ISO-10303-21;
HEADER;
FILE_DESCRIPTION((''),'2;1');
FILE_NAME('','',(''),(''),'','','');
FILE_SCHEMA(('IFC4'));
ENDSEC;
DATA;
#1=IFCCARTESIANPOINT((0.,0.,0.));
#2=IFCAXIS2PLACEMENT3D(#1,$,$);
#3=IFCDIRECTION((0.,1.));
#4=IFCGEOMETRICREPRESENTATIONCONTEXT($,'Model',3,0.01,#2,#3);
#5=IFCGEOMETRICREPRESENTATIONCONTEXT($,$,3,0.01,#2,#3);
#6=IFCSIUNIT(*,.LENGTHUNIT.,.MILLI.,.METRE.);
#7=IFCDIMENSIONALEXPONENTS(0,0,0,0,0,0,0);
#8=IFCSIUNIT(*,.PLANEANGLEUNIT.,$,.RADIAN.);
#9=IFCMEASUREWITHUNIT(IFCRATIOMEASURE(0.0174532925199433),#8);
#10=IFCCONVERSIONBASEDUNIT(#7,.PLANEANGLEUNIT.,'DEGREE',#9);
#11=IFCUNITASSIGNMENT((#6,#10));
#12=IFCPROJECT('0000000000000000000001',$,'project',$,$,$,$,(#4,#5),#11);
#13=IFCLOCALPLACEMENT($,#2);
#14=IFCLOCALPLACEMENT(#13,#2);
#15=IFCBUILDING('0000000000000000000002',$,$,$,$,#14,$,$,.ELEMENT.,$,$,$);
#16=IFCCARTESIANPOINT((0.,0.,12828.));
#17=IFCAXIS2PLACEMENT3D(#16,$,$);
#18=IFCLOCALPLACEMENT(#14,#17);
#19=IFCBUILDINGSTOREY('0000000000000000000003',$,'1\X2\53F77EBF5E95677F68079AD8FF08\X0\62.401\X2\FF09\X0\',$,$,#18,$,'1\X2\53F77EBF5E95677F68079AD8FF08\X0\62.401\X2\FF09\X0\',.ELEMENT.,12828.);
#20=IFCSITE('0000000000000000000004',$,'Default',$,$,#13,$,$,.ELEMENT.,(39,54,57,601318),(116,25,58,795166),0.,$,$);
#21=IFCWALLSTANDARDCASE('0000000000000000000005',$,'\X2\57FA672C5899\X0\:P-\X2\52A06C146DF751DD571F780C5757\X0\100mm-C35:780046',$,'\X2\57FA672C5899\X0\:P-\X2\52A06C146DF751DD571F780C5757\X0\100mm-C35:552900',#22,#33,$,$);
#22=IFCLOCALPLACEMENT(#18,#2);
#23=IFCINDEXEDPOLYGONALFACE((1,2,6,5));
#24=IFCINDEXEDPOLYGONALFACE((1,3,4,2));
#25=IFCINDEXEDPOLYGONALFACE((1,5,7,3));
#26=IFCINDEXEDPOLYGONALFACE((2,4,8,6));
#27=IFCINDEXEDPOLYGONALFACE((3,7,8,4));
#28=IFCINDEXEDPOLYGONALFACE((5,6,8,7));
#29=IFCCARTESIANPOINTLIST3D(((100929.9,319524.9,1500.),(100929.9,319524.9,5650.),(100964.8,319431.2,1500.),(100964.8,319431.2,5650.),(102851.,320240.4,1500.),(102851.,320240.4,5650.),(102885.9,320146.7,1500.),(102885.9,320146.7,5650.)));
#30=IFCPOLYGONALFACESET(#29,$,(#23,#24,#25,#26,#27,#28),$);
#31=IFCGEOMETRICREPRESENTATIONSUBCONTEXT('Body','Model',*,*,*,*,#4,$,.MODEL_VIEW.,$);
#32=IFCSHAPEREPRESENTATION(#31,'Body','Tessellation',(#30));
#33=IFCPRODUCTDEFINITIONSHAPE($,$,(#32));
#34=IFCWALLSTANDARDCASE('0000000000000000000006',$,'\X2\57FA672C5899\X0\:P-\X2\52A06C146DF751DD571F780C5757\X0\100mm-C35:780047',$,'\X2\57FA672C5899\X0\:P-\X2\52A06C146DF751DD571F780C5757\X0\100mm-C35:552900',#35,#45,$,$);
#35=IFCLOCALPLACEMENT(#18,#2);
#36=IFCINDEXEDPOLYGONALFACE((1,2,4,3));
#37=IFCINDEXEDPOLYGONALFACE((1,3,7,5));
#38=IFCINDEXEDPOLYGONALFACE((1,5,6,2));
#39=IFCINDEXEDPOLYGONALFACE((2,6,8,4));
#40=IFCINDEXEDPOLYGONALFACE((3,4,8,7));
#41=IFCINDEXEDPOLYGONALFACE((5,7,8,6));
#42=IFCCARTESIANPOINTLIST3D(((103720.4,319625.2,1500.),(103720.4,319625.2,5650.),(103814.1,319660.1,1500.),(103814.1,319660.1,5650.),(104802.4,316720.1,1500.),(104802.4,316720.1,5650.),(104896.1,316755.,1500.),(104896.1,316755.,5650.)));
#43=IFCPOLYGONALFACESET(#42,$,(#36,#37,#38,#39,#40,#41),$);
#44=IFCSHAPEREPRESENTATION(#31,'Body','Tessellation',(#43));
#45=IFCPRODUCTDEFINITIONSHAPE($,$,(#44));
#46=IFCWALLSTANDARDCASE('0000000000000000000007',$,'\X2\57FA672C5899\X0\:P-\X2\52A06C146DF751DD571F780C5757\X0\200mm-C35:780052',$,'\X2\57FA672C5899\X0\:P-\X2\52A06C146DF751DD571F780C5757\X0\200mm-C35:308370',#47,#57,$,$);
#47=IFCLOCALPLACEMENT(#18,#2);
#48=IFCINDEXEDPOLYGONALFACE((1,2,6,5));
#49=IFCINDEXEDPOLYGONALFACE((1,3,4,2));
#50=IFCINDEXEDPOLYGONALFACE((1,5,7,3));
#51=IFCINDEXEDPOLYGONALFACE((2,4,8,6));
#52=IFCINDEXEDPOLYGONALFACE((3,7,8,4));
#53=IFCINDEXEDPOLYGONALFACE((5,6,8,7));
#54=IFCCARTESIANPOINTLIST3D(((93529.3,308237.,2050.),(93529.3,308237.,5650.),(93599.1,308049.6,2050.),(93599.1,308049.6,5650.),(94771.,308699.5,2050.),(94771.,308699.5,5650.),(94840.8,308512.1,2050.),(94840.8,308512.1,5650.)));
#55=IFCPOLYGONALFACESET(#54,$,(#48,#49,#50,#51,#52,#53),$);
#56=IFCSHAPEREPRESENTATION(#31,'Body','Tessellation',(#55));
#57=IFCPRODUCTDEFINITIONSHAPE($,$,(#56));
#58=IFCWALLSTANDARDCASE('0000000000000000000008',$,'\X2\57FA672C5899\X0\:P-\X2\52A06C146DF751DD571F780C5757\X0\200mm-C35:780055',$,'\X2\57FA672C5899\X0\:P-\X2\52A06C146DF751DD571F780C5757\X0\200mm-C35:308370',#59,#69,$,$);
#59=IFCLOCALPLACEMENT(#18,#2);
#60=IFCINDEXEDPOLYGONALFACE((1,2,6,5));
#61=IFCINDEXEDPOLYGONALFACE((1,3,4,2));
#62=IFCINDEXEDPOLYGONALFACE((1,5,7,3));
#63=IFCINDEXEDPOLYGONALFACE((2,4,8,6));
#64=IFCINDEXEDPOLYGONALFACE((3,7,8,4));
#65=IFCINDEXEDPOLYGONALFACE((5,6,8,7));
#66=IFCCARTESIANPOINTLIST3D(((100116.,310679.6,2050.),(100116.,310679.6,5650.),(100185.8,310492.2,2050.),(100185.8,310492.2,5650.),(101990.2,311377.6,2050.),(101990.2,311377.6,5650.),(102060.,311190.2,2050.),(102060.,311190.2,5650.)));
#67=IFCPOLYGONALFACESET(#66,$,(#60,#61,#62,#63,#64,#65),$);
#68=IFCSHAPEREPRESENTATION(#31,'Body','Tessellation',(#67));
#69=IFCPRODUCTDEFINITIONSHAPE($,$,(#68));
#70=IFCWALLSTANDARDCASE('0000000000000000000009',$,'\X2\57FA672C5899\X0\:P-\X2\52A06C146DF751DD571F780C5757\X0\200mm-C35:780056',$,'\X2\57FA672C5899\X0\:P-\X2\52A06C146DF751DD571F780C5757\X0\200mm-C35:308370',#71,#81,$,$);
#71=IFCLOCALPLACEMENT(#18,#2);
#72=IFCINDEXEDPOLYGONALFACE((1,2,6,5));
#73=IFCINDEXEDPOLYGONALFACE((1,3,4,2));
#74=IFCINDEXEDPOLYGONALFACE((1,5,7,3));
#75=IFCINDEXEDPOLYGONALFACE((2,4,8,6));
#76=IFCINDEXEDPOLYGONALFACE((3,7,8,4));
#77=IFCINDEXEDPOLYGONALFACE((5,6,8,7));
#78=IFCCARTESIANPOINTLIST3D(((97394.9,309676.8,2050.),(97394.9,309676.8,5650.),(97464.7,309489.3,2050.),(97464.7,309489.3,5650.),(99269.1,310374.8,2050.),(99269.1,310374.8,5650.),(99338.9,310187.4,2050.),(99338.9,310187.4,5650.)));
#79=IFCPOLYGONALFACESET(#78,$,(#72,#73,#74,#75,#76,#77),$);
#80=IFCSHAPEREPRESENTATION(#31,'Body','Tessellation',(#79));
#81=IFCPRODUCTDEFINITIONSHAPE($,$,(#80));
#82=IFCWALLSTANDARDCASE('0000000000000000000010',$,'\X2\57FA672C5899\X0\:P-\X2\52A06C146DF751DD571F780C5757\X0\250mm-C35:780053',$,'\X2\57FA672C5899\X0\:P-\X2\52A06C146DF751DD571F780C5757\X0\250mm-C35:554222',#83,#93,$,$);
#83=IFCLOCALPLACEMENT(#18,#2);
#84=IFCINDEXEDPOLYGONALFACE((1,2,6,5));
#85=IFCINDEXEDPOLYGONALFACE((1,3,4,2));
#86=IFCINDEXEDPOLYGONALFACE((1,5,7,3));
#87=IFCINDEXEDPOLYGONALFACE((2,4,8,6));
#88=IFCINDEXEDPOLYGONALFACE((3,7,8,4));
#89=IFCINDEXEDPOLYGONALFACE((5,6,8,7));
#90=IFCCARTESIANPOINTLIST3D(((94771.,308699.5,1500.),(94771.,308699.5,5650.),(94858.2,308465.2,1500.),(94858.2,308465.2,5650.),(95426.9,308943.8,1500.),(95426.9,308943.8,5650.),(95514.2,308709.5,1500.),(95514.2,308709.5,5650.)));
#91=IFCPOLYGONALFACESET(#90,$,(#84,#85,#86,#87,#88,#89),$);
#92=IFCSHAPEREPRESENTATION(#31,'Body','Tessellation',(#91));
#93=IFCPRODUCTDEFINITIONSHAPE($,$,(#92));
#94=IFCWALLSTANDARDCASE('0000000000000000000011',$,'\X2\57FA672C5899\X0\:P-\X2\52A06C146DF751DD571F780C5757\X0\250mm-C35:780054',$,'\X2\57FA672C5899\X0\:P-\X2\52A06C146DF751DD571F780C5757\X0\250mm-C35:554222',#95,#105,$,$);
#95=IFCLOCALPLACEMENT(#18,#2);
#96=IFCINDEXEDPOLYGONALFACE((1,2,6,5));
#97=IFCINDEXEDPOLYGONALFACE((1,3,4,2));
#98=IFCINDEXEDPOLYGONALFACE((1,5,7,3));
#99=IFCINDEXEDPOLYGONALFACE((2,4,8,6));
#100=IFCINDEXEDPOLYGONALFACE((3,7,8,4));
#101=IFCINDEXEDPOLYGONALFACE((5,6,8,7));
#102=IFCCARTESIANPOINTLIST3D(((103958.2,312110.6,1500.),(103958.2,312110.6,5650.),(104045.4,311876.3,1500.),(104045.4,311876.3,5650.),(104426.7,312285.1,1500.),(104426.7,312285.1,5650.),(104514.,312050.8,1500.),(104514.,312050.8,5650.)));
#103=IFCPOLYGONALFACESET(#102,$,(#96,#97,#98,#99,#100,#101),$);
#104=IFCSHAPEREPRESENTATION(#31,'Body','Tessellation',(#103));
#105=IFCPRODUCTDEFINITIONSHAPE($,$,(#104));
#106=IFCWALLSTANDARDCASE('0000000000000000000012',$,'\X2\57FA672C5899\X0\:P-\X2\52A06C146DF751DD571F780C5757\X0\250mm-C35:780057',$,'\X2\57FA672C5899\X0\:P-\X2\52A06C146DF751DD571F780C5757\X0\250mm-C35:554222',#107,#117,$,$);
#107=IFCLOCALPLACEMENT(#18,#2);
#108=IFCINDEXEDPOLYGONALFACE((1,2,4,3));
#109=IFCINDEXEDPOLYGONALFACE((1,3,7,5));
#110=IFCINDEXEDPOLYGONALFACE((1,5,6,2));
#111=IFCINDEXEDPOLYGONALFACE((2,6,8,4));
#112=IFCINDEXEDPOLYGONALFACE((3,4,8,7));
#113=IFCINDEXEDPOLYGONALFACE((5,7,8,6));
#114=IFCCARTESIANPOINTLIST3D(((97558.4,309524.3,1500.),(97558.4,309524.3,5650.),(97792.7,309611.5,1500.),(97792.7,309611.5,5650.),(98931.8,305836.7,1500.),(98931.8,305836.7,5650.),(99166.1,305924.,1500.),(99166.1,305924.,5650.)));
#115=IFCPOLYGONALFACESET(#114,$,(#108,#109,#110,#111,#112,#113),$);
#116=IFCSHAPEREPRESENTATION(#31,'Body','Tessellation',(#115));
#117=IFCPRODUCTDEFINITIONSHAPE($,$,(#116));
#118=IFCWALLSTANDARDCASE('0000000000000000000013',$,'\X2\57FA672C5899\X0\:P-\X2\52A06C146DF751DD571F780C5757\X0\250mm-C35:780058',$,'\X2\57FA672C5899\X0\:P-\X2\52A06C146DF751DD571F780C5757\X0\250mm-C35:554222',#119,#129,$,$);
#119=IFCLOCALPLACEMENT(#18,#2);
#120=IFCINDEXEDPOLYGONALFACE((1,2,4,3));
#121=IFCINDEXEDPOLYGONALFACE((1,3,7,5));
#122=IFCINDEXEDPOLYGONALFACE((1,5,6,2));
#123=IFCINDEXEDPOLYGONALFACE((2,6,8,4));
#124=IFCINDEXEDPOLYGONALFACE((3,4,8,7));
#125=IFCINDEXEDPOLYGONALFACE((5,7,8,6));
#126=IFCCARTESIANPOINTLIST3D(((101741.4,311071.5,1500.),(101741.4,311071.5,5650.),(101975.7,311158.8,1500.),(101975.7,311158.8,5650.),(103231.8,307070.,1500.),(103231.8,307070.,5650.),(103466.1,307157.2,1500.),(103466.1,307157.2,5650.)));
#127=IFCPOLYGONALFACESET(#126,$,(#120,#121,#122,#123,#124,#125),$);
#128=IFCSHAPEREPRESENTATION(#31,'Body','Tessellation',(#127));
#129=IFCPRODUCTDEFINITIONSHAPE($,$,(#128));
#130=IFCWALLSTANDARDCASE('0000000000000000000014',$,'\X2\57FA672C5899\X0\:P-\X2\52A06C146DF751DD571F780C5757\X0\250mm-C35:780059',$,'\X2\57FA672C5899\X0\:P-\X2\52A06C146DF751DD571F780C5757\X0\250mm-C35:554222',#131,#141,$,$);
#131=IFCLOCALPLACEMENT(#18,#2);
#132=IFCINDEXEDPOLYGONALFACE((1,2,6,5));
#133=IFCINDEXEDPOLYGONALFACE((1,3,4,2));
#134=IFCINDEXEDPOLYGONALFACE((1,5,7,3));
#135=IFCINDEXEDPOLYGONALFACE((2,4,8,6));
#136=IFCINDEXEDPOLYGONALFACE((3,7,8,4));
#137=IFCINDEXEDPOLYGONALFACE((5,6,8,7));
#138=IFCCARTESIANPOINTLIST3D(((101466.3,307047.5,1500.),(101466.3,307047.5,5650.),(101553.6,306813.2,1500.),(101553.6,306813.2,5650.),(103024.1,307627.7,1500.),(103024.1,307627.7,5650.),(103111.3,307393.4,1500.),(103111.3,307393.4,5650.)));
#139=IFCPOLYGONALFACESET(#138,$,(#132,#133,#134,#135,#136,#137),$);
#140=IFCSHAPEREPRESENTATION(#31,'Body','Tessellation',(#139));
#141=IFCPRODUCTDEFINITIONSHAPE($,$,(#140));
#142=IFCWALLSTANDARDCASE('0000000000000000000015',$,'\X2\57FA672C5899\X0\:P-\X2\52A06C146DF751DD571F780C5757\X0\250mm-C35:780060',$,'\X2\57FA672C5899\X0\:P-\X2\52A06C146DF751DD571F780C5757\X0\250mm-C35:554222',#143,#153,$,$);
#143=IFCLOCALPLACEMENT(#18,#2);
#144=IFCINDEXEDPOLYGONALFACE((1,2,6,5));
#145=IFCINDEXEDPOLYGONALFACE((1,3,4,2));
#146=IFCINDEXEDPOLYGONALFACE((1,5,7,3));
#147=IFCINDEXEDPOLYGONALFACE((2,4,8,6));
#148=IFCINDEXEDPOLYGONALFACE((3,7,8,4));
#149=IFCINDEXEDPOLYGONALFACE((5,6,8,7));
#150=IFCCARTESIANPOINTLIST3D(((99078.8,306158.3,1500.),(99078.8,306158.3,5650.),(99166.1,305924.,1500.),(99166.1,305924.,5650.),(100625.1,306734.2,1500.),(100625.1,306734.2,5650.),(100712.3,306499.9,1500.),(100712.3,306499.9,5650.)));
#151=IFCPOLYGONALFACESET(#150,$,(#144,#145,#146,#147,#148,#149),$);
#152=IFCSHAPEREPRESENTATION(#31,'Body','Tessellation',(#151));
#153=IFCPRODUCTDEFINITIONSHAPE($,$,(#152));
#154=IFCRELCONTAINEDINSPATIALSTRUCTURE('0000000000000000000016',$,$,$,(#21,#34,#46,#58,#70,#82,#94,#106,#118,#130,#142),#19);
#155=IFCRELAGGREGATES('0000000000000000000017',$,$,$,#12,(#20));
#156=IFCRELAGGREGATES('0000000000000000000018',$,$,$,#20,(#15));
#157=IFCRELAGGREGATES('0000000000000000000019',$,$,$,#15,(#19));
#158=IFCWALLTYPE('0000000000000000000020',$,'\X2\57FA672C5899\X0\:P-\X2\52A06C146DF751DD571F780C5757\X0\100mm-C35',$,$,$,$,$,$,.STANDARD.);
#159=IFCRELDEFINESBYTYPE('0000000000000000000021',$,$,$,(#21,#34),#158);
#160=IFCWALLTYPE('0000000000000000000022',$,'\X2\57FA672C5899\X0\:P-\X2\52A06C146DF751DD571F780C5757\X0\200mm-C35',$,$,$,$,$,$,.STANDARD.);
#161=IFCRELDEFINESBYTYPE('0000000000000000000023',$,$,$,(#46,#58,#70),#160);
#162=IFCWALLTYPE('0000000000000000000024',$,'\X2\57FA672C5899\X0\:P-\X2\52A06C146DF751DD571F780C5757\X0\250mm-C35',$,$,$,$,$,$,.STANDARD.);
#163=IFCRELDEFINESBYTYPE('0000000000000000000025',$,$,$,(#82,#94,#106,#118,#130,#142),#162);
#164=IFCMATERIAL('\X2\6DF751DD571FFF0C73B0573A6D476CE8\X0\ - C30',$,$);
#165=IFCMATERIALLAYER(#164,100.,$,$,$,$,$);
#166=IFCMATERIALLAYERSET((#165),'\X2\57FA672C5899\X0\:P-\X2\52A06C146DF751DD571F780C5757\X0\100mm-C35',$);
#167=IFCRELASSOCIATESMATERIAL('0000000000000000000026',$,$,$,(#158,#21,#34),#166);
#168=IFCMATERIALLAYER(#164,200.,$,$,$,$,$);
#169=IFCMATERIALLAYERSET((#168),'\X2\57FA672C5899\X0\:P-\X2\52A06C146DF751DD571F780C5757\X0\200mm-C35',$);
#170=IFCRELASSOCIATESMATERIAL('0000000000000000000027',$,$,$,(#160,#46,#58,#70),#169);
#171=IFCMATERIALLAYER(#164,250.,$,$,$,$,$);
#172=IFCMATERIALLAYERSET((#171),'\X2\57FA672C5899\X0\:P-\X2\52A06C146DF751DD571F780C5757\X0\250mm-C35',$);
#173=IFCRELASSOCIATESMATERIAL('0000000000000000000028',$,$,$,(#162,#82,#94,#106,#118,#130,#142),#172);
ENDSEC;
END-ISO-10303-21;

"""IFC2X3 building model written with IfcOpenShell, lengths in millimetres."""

from ifc_helpers import new_model, entity, si_unit, converted_unit, direction, frame, frame_2d, origin, place, context, subcontext, project, spatial, polyline, rectangle, extrude, clip, bounded_halfspace, material, layer, layer_set, layer_usage, type_object, element, save


model = new_model("IFC2X3")

# Units and contexts
model_context = context("Model", 3, precision=0.01, world=origin(), true_north=direction((0.0, 1.0)))
context_of_model = context(None, 3, precision=0.01, world=origin(), true_north=direction((0.0, 1.0)))
body_context = subcontext(model_context, "Body", "Model", "MODEL_VIEW")
ifc_project = project(units=[si_unit("LENGTHUNIT", "METRE", prefix="MILLI"), converted_unit("PLANEANGLEUNIT", "DEGREE", entity("IfcRatioMeasure", 0.0174532925199433), si_unit("PLANEANGLEUNIT", "RADIAN"), dimensions=[0, 0, 0, 0, 0, 0, 0])], contexts=[model_context, context_of_model])

# Site, building, storey
site_placement = place(None, origin())
site = spatial("IfcSite", under=ifc_project, at=site_placement, Name="Default", CompositionType="ELEMENT", RefLatitude=(39, 54, 57, 601318), RefLongitude=(116, 25, 58, 795166), RefElevation=0.0)
building_placement = place(site_placement, origin())
building = spatial("IfcBuilding", under=site, at=building_placement, CompositionType="ELEMENT")
storey_placement = place(building_placement, frame((0.0, 0.0, 12828.0)))
storey = spatial("IfcBuildingStorey", under=building, at=storey_placement, Name="1号线底板标高（62.401）", LongName="1号线底板标高（62.401）", CompositionType="ELEMENT", Elevation=12828.0)

# Walls
ifc_material_1 = material(Name="混凝土，现场浇注 - C30")
ifc_layer_1 = layer(ifc_material_1, 100.0)
ifc_layer_set_1 = layer_set([ifc_layer_1], Name="基本墙:P-加气混凝土砌块100mm-C35")
ifc_layer_usage_1 = layer_usage(ifc_layer_set_1, "AXIS2", "NEGATIVE", 50.0)
wall_type_1 = type_object("IfcWallType", Name="基本墙:P-加气混凝土砌块100mm-C35", PredefinedType="STANDARD", material=ifc_layer_set_1)
wall_1_placement = place(storey_placement, frame((100947.4, 319478.1, 1500.0), z_axis=(0.0, 0.0, 1.0), x_axis=(0.937112, 0.349028, 0.0)))
element("IfcWallStandardCase", 1, at=wall_1_placement, inside=storey, type_object=wall_type_1, material=ifc_layer_usage_1, Name="基本墙:P-加气混凝土砌块100mm-C35:780046", ObjectType="基本墙:P-加气混凝土砌块100mm-C35:552900", context=body_context, shape_type="Clipping", body=[
    clip(extrude(rectangle(XDim=2050.0, YDim=100.0, at=frame_2d((1025.0, 0.0), x_axis=(-1.0, 0.0))), origin(), (0.0, 0.0, 1.0), 4150.0), bounded_halfspace(frame((0.0, -50.0, 4150.0), z_axis=(0.0, 0.0, -1.0), x_axis=(1.0, 0.0, 0.0)), True, frame((0.0, -50.0, 4150.0)), polyline([(0.0, 0.0), (2050.0, 0.0), (2050.0, 100.0), (0.0, 100.0), (0.0, 0.0)]))),
])
ifc_layer_usage_2 = layer_usage(ifc_layer_set_1, "AXIS2", "NEGATIVE", 50.0)
wall_2_placement = place(storey_placement, frame((103767.3, 319642.6, 1500.0), z_axis=(0.0, 0.0, 1.0), x_axis=(0.349028, -0.937112, 0.0)))
element("IfcWallStandardCase", 2, at=wall_2_placement, inside=storey, type_object=wall_type_1, material=ifc_layer_usage_2, Name="基本墙:P-加气混凝土砌块100mm-C35:780047", ObjectType="基本墙:P-加气混凝土砌块100mm-C35:552900", context=body_context, shape_type="Clipping", body=[
    clip(extrude(rectangle(XDim=3100.0, YDim=100.0, at=frame_2d((1550.0, 0.0), x_axis=(-1.0, 0.0))), origin(), (0.0, 0.0, 1.0), 4150.0), bounded_halfspace(frame((0.0, -50.0, 4150.0), z_axis=(0.0, 0.0, -1.0), x_axis=(0.0, 1.0, 0.0)), True, frame((0.0, -50.0, 4150.0)), polyline([(0.0, 0.0), (3100.0, 0.0), (3100.0, 100.0), (0.0, 100.0), (0.0, 0.0)]))),
])
ifc_layer_2 = layer(ifc_material_1, 200.0)
ifc_layer_set_2 = layer_set([ifc_layer_2], Name="基本墙:P-加气混凝土砌块200mm-C35")
ifc_layer_usage_3 = layer_usage(ifc_layer_set_2, "AXIS2", "NEGATIVE", 100.0)
wall_type_2 = type_object("IfcWallType", Name="基本墙:P-加气混凝土砌块200mm-C35", PredefinedType="STANDARD", material=ifc_layer_set_2)
wall_3_placement = place(storey_placement, frame((94805.9, 308605.8, 2050.0), z_axis=(0.0, 0.0, 1.0), x_axis=(-0.937112, -0.349028, 0.0)))
element("IfcWallStandardCase", 3, at=wall_3_placement, inside=storey, type_object=wall_type_2, material=ifc_layer_usage_3, Name="基本墙:P-加气混凝土砌块200mm-C35:780052", ObjectType="基本墙:P-加气混凝土砌块200mm-C35:308370", context=body_context, shape_type="Clipping", body=[
    clip(extrude(rectangle(XDim=1325.0, YDim=200.0, at=frame_2d((662.5, 0.0), x_axis=(-1.0, 0.0))), origin(), (0.0, 0.0, 1.0), 3600.0), bounded_halfspace(frame((0.0, -100.0, 3600.0), z_axis=(0.0, 0.0, -1.0), x_axis=(-1.0, 0.0, 0.0)), True, frame((0.0, -100.0, 3600.0)), polyline([(0.0, 0.0), (1325.0, 0.0), (1325.0, 200.0), (0.0, 200.0), (0.0, 0.0)]))),
])
ifc_layer_usage_4 = layer_usage(ifc_layer_set_2, "AXIS2", "NEGATIVE", 100.0)
wall_4_placement = place(storey_placement, frame((100150.9, 310585.9, 2050.0), z_axis=(0.0, 0.0, 1.0), x_axis=(0.937112, 0.349028, 0.0)))
element("IfcWallStandardCase", 4, at=wall_4_placement, inside=storey, type_object=wall_type_2, material=ifc_layer_usage_4, Name="基本墙:P-加气混凝土砌块200mm-C35:780055", ObjectType="基本墙:P-加气混凝土砌块200mm-C35:308370", context=body_context, shape_type="Clipping", body=[
    clip(extrude(rectangle(XDim=2000.0, YDim=200.0, at=frame_2d((1000.0, 0.0), x_axis=(-1.0, 0.0))), origin(), (0.0, 0.0, 1.0), 3600.0), bounded_halfspace(frame((0.0, -100.0, 3600.0), z_axis=(0.0, 0.0, -1.0), x_axis=(1.0, 0.0, 0.0)), True, frame((0.0, -100.0, 3600.0)), polyline([(0.0, 0.0), (1660.0, 0.0), (1910.0, 0.0), (2000.0, 0.0), (2000.0, 200.0), (0.0, 200.0), (0.0, 0.0)]))),
])
ifc_layer_usage_5 = layer_usage(ifc_layer_set_2, "AXIS2", "NEGATIVE", 100.0)
wall_5_placement = place(storey_placement, frame((97429.8, 309583.1, 2050.0), z_axis=(0.0, 0.0, 1.0), x_axis=(0.937112, 0.349028, 0.0)))
element("IfcWallStandardCase", 5, at=wall_5_placement, inside=storey, type_object=wall_type_2, material=ifc_layer_usage_5, Name="基本墙:P-加气混凝土砌块200mm-C35:780056", ObjectType="基本墙:P-加气混凝土砌块200mm-C35:308370", context=body_context, shape_type="Clipping", body=[
    clip(extrude(rectangle(XDim=2000.0, YDim=200.0, at=frame_2d((1000.0, 0.0), x_axis=(-1.0, 0.0))), origin(), (0.0, 0.0, 1.0), 3600.0), bounded_halfspace(frame((0.0, -100.0, 3600.0), z_axis=(0.0, 0.0, -1.0), x_axis=(1.0, 0.0, 0.0)), True, frame((0.0, -100.0, 3600.0)), polyline([(0.0, 0.0), (100.0, 0.0), (350.0, 0.0), (2000.0, 0.0), (2000.0, 200.0), (0.0, 200.0), (0.0, 0.0)]))),
])
ifc_layer_3 = layer(ifc_material_1, 250.0)
ifc_layer_set_3 = layer_set([ifc_layer_3], Name="基本墙:P-加气混凝土砌块250mm-C35")
ifc_layer_usage_6 = layer_usage(ifc_layer_set_3, "AXIS2", "NEGATIVE", 125.0)
wall_type_3 = type_object("IfcWallType", Name="基本墙:P-加气混凝土砌块250mm-C35", PredefinedType="STANDARD", material=ifc_layer_set_3)
wall_6_placement = place(storey_placement, frame((94814.6, 308582.4, 1500.0), z_axis=(0.0, 0.0, 1.0), x_axis=(0.937112, 0.349028, 0.0)))
element("IfcWallStandardCase", 6, at=wall_6_placement, inside=storey, type_object=wall_type_3, material=ifc_layer_usage_6, Name="基本墙:P-加气混凝土砌块250mm-C35:780053", ObjectType="基本墙:P-加气混凝土砌块250mm-C35:554222", context=body_context, shape_type="Clipping", body=[
    clip(extrude(rectangle(XDim=700.0, YDim=250.0, at=frame_2d((350.0, 0.0), x_axis=(-1.0, 0.0))), origin(), (0.0, 0.0, 1.0), 4150.0), bounded_halfspace(frame((0.0, -125.0, 4150.0), z_axis=(0.0, 0.0, -1.0), x_axis=(1.0, 0.0, 0.0)), True, frame((0.0, -125.0, 4150.0)), polyline([(0.0, 0.0), (700.0, 0.0), (700.0, 250.0), (0.0, 250.0), (0.0, 50.0), (0.0, 0.0)]))),
])
ifc_layer_usage_7 = layer_usage(ifc_layer_set_3, "AXIS2", "NEGATIVE", 125.0)
wall_7_placement = place(storey_placement, frame((104001.8, 311993.5, 1500.0), z_axis=(0.0, 0.0, 1.0), x_axis=(0.937112, 0.349028, 0.0)))
element("IfcWallStandardCase", 7, at=wall_7_placement, inside=storey, type_object=wall_type_3, material=ifc_layer_usage_7, Name="基本墙:P-加气混凝土砌块250mm-C35:780054", ObjectType="基本墙:P-加气混凝土砌块250mm-C35:554222", context=body_context, shape_type="Clipping", body=[
    clip(extrude(rectangle(XDim=500.0, YDim=250.0, at=frame_2d((250.0, 0.0), x_axis=(-1.0, 0.0))), origin(), (0.0, 0.0, 1.0), 4150.0), bounded_halfspace(frame((0.0, -125.0, 4150.0), z_axis=(0.0, 0.0, -1.0), x_axis=(1.0, 0.0, 0.0)), True, frame((0.0, -125.0, 4150.0)), polyline([(0.0, 0.0), (500.0, 0.0), (500.0, 50.0), (500.0, 250.0), (0.0, 250.0), (0.0, 0.0)]))),
])
ifc_layer_usage_8 = layer_usage(ifc_layer_set_3, "AXIS2", "NEGATIVE", 125.0)
wall_8_placement = place(storey_placement, frame((97675.5, 309567.9, 1500.0), z_axis=(0.0, 0.0, 1.0), x_axis=(0.349028, -0.937112, 0.0)))
element("IfcWallStandardCase", 8, at=wall_8_placement, inside=storey, type_object=wall_type_3, material=ifc_layer_usage_8, Name="基本墙:P-加气混凝土砌块250mm-C35:780057", ObjectType="基本墙:P-加气混凝土砌块250mm-C35:554222", context=body_context, shape_type="Clipping", body=[
    clip(extrude(rectangle(XDim=3935.0, YDim=250.0, at=frame_2d((1967.5, 0.0), x_axis=(-1.0, 0.0))), origin(), (0.0, 0.0, 1.0), 4150.0), bounded_halfspace(frame((0.0, -125.0, 4150.0), z_axis=(0.0, 0.0, -1.0), x_axis=(0.0, 1.0, 0.0)), True, frame((0.0, -125.0, 4150.0)), polyline([(0.0, 0.0), (3935.0, 0.0), (3935.0, 250.0), (3685.0, 250.0), (835.0, 250.0), (585.0, 250.0), (0.0, 250.0), (0.0, 0.0)]))),
])
ifc_layer_usage_9 = layer_usage(ifc_layer_set_3, "AXIS2", "NEGATIVE", 125.0)
wall_9_placement = place(storey_placement, frame((101858.5, 311115.2, 1500.0), z_axis=(0.0, 0.0, 1.0), x_axis=(0.349028, -0.937112, 0.0)))
element("IfcWallStandardCase", 9, at=wall_9_placement, inside=storey, type_object=wall_type_3, material=ifc_layer_usage_9, Name="基本墙:P-加气混凝土砌块250mm-C35:780058", ObjectType="基本墙:P-加气混凝土砌块250mm-C35:554222", context=body_context, shape_type="Clipping", body=[
    clip(extrude(rectangle(XDim=4270.1, YDim=250.0, at=frame_2d((2135.1, 0.0), x_axis=(-1.0, 0.0))), origin(), (0.0, 0.0, 1.0), 4150.0), bounded_halfspace(frame((0.0, -125.0, 4150.0), z_axis=(0.0, 0.0, -1.0), x_axis=(0.0, 1.0, 0.0)), True, frame((0.0, -125.0, 4150.0)), polyline([(0.0, 0.0), (3675.0, 0.0), (3925.0, 0.0), (4270.1, 0.0), (4270.1, 250.0), (0.0, 250.0), (0.0, 0.0)]))),
])
ifc_layer_usage_10 = layer_usage(ifc_layer_set_3, "AXIS2", "NEGATIVE", 125.0)
wall_10_placement = place(storey_placement, frame((103067.7, 307510.5, 1500.0), z_axis=(0.0, 0.0, 1.0), x_axis=(-0.937112, -0.349028, 0.0)))
element("IfcWallStandardCase", 10, at=wall_10_placement, inside=storey, type_object=wall_type_3, material=ifc_layer_usage_10, Name="基本墙:P-加气混凝土砌块250mm-C35:780059", ObjectType="基本墙:P-加气混凝土砌块250mm-C35:554222", context=body_context, shape_type="Clipping", body=[
    clip(extrude(rectangle(XDim=1662.3, YDim=250.0, at=frame_2d((831.1, 0.0), x_axis=(-1.0, 0.0))), origin(), (0.0, 0.0, 1.0), 4150.0), bounded_halfspace(frame((0.0, -125.0, 4150.0), z_axis=(0.0, 0.0, -1.0), x_axis=(-1.0, 0.0, 0.0)), True, frame((0.0, -125.0, 4150.0)), polyline([(0.0, 0.0), (1662.3, 0.0), (1662.3, 250.0), (0.0, 250.0), (0.0, 0.0)]))),
])
ifc_layer_usage_11 = layer_usage(ifc_layer_set_3, "AXIS2", "NEGATIVE", 125.0)
wall_11_placement = place(storey_placement, frame((100668.7, 306617.0, 1500.0), z_axis=(0.0, 0.0, 1.0), x_axis=(-0.937112, -0.349028, 0.0)))
element("IfcWallStandardCase", 11, at=wall_11_placement, inside=storey, type_object=wall_type_3, material=ifc_layer_usage_11, Name="基本墙:P-加气混凝土砌块250mm-C35:780060", ObjectType="基本墙:P-加气混凝土砌块250mm-C35:554222", context=body_context, shape_type="Clipping", body=[
    clip(extrude(rectangle(XDim=1650.0, YDim=250.0, at=frame_2d((825.0, 0.0), x_axis=(-1.0, 0.0))), origin(), (0.0, 0.0, 1.0), 4150.0), bounded_halfspace(frame((0.0, -125.0, 4150.0), z_axis=(0.0, 0.0, -1.0), x_axis=(-1.0, 0.0, 0.0)), True, frame((0.0, -125.0, 4150.0)), polyline([(0.0, 0.0), (1650.0, 0.0), (1650.0, 250.0), (0.0, 250.0), (0.0, 0.0)]))),
])

save(model, "model.ifc")
